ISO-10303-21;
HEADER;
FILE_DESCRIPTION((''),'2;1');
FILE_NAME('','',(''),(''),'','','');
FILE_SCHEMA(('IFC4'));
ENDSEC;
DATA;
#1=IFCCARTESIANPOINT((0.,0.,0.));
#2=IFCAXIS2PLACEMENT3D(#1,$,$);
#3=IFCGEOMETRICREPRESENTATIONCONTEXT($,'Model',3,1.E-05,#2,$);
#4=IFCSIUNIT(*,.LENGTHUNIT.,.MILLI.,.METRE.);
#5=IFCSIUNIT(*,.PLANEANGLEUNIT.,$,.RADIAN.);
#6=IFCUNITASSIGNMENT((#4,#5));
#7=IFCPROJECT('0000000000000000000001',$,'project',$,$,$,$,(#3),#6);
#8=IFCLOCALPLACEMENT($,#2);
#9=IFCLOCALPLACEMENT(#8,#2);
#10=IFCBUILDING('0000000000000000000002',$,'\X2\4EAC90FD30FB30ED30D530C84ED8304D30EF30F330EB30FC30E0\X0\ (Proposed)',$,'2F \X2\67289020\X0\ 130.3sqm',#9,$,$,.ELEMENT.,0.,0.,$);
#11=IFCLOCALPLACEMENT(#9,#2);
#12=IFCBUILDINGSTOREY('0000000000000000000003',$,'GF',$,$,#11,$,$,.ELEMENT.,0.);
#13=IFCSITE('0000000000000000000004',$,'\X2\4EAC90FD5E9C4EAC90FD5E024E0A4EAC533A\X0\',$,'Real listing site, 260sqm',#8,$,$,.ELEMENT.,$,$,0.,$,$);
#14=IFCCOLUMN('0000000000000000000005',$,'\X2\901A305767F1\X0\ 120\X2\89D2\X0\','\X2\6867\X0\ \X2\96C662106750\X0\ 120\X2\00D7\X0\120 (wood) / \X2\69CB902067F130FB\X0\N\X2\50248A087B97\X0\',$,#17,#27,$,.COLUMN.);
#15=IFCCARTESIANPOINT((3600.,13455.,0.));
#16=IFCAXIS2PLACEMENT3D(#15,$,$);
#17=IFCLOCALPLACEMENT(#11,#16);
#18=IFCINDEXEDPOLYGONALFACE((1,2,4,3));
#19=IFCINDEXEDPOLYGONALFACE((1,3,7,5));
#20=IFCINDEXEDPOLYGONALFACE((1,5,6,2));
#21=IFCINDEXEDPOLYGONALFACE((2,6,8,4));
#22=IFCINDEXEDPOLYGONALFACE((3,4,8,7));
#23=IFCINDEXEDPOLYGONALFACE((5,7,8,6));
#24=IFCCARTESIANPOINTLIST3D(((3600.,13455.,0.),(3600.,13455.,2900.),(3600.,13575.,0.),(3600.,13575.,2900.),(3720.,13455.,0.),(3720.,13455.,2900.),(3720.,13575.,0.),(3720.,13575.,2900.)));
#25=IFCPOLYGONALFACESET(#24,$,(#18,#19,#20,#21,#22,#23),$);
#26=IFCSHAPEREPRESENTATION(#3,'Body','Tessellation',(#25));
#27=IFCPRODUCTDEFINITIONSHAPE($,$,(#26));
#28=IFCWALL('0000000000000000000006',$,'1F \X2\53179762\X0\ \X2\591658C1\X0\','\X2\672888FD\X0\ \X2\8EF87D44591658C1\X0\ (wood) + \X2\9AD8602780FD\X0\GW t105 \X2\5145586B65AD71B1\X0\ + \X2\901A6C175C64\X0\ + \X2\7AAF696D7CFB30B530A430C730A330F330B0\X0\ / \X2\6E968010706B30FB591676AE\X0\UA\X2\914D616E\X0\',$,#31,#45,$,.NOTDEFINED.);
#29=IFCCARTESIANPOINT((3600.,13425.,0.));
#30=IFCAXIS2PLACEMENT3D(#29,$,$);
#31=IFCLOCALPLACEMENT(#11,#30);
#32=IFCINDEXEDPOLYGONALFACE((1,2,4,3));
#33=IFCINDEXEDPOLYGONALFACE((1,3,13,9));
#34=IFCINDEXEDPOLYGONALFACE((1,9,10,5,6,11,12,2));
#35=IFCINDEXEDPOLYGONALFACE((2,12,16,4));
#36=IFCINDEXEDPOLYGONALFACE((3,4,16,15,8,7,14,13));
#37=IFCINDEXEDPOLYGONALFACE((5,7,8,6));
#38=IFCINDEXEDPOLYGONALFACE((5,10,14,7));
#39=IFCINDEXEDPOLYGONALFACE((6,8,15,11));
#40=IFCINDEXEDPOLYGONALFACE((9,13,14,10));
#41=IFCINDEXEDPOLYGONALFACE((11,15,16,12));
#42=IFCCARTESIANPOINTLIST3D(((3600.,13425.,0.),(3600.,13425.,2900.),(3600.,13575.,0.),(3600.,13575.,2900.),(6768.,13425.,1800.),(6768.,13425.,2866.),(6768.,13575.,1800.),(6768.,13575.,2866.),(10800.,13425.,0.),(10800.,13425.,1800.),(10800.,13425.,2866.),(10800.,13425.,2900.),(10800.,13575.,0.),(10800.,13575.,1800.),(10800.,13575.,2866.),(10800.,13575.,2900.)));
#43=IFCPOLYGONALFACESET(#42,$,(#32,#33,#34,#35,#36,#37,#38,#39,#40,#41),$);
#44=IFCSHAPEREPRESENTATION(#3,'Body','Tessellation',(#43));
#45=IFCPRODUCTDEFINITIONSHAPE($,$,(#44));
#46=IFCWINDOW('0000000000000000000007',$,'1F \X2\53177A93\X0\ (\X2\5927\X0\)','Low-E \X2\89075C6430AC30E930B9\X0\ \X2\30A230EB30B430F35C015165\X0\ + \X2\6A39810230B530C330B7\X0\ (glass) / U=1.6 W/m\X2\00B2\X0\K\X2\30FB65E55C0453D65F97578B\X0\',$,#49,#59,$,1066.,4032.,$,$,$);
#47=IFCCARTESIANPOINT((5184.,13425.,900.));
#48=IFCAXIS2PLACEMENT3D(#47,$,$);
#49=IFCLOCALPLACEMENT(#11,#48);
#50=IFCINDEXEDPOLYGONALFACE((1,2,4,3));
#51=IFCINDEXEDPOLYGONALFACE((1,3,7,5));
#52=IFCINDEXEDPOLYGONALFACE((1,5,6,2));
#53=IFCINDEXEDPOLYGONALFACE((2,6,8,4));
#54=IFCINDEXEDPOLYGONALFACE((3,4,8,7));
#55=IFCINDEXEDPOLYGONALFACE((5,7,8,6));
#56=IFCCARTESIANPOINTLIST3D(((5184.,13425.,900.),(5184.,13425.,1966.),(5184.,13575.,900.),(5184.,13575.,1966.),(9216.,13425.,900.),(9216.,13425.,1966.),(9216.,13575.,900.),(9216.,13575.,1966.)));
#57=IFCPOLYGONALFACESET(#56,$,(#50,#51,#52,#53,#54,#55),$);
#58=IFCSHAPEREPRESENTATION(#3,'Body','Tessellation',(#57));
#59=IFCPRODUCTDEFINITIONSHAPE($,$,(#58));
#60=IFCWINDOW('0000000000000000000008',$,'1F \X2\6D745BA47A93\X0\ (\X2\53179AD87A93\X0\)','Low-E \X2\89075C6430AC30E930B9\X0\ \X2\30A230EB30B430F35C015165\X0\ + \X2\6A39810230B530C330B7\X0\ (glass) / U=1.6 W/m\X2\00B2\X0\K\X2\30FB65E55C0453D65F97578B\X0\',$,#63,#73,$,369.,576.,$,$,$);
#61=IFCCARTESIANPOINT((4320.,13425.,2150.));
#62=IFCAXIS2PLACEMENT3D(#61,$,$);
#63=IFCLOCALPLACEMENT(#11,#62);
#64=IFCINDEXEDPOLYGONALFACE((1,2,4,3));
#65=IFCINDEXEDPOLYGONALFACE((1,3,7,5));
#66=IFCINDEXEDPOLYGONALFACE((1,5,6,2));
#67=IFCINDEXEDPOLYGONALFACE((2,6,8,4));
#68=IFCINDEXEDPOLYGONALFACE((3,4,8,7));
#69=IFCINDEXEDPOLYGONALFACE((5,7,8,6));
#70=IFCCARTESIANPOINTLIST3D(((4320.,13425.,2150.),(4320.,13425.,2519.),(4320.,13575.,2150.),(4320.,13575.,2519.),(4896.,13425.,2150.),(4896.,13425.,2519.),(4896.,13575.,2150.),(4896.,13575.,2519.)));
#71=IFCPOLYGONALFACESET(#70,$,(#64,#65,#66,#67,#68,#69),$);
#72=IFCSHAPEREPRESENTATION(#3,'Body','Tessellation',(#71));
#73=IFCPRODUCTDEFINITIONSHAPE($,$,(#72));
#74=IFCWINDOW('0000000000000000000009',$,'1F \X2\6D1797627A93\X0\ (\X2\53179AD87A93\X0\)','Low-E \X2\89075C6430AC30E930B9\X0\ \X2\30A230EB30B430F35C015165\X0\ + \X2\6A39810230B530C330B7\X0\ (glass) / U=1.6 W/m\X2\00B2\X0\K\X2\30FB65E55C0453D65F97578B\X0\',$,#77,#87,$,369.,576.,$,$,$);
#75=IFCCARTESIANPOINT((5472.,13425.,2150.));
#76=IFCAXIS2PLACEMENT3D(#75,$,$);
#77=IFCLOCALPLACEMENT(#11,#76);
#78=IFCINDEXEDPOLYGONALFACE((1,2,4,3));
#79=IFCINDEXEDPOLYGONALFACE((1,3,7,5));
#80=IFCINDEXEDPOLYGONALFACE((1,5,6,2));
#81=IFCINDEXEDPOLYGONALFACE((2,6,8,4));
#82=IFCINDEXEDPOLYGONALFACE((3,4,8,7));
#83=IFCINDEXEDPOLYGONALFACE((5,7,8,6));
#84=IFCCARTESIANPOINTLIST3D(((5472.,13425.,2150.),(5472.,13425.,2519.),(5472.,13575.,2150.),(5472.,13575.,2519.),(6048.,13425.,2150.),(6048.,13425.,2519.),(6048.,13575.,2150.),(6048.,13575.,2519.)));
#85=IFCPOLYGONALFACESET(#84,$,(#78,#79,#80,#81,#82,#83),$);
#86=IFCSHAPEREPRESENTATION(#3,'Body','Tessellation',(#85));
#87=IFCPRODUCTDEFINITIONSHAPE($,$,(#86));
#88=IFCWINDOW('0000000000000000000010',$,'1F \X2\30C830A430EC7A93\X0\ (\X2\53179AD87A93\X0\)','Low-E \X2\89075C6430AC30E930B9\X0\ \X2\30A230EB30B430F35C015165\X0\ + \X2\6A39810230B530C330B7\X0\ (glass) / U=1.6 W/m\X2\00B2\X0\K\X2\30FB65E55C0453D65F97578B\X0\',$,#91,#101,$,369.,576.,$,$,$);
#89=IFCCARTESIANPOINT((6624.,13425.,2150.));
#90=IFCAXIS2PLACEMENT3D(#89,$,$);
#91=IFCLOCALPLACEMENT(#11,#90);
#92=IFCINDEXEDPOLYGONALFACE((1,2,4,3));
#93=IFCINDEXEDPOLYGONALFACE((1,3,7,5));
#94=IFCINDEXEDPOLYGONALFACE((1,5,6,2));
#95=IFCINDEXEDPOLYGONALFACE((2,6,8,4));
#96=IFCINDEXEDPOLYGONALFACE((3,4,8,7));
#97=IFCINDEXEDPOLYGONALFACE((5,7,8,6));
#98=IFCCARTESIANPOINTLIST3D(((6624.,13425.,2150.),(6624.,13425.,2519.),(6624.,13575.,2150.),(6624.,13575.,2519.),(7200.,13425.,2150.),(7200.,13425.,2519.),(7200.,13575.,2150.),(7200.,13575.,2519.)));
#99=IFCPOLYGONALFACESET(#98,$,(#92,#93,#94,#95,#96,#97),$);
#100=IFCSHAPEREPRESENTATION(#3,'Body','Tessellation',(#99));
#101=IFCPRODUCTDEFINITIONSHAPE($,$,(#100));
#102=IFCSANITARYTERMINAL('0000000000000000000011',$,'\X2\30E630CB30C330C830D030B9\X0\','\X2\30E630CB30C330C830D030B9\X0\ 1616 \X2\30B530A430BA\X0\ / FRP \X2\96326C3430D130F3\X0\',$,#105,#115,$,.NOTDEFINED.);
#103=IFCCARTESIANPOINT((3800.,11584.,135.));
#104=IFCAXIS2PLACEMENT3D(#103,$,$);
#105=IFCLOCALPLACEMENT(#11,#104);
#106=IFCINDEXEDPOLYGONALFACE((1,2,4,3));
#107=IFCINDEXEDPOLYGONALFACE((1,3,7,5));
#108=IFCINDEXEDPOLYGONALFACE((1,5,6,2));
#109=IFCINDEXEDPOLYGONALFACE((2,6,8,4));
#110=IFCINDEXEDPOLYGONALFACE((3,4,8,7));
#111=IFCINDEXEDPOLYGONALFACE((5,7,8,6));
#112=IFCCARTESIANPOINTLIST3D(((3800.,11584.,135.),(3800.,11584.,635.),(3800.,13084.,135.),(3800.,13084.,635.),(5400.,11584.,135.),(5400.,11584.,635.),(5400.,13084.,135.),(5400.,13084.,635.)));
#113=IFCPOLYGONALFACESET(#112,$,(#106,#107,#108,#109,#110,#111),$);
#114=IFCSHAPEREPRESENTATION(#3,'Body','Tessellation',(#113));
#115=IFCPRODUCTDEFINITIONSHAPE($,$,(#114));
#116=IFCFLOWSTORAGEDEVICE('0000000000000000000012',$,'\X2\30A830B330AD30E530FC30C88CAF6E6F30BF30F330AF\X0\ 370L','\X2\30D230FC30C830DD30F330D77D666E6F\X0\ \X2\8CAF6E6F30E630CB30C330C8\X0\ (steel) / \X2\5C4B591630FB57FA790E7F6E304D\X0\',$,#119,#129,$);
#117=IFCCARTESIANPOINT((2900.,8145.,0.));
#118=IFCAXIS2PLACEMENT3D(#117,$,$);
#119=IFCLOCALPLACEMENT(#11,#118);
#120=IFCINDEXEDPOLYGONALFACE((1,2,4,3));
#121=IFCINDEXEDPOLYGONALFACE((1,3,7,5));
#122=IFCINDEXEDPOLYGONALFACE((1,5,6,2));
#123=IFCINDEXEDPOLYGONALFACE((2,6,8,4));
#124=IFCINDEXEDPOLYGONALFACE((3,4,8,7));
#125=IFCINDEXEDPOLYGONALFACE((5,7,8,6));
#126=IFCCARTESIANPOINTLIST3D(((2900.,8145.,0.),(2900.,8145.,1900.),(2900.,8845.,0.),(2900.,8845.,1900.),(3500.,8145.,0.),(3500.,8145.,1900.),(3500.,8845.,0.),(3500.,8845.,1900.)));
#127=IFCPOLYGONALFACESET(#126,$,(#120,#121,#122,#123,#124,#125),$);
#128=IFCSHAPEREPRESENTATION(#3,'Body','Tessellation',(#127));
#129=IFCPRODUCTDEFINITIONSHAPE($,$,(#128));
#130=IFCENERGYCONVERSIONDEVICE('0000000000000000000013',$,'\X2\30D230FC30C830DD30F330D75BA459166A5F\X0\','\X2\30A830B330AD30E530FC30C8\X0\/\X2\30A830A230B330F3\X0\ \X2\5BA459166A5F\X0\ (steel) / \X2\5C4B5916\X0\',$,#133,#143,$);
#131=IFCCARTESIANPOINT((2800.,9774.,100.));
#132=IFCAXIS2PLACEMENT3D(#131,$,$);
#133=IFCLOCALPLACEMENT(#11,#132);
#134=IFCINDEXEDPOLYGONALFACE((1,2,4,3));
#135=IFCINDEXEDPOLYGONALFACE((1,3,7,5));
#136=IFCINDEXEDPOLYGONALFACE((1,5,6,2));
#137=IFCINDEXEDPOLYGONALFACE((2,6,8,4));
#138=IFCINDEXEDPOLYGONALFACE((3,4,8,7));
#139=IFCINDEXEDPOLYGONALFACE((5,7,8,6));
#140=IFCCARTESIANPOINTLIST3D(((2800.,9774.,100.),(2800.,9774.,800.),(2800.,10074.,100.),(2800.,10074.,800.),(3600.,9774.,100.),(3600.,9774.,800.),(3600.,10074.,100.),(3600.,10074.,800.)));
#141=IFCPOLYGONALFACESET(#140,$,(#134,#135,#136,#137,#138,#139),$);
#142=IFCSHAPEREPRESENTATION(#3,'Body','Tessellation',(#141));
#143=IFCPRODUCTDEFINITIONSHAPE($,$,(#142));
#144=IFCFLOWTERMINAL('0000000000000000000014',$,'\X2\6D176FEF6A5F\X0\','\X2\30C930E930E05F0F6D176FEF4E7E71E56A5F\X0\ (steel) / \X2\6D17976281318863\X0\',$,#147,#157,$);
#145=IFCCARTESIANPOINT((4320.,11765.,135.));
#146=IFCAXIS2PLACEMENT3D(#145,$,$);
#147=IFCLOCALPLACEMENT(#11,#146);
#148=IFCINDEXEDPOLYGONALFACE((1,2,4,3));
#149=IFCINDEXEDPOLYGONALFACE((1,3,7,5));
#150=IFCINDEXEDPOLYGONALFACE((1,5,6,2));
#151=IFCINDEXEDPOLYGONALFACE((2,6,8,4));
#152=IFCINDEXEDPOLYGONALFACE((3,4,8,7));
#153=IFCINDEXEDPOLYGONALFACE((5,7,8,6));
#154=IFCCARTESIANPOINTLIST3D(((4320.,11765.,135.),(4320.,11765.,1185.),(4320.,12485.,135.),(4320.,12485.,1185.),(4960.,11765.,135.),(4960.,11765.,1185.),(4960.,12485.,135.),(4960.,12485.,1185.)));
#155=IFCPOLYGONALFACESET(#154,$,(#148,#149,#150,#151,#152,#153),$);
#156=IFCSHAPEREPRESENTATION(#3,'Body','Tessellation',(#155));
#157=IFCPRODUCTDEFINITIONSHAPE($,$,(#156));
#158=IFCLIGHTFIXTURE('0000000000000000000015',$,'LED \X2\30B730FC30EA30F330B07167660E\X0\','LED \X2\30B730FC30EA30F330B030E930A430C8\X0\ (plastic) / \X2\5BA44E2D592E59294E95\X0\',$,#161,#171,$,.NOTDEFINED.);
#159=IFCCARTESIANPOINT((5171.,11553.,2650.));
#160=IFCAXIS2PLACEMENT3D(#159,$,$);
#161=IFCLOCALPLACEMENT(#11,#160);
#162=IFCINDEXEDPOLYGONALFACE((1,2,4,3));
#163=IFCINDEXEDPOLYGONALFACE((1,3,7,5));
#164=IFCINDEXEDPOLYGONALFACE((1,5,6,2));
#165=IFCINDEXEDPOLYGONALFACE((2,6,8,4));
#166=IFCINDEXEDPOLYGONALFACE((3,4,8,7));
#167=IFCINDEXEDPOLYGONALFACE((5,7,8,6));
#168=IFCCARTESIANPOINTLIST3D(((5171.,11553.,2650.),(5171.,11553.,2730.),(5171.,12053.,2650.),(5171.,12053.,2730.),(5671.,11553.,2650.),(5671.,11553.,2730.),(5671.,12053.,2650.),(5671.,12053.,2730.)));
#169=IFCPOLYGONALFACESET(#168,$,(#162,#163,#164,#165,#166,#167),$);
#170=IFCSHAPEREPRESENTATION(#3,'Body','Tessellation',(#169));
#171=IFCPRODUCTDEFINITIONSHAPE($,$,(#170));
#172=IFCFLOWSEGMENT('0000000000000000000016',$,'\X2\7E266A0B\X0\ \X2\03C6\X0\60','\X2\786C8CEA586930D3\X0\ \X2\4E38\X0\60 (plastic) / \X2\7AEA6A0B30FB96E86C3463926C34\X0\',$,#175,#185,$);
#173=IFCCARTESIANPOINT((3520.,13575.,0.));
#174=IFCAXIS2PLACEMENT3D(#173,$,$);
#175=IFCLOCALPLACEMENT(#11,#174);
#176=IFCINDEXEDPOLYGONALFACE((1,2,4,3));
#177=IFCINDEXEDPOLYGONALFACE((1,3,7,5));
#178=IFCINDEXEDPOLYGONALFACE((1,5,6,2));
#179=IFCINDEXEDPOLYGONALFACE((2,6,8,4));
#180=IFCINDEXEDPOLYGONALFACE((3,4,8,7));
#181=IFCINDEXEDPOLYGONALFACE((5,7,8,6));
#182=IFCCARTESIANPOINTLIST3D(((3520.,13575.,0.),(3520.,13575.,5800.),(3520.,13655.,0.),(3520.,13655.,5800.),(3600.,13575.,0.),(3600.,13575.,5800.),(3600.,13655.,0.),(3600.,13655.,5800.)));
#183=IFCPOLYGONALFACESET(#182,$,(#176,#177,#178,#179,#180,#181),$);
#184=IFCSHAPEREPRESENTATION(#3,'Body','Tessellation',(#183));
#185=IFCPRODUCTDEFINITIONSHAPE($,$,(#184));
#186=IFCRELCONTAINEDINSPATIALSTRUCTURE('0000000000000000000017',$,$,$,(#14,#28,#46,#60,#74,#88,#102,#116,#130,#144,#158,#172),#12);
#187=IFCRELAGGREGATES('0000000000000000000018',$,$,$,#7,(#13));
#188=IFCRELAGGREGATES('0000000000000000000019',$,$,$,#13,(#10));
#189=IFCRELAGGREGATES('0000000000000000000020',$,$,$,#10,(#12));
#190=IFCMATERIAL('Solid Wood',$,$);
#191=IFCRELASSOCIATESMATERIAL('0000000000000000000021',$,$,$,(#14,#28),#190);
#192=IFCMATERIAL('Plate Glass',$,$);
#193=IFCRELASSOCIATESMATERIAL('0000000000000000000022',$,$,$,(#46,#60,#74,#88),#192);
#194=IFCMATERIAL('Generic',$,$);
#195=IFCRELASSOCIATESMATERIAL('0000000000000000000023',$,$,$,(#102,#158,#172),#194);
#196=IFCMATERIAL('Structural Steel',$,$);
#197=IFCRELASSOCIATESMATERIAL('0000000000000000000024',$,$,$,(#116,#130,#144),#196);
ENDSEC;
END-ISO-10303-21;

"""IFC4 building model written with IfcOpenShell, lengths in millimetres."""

from ifc_helpers import new_model, si_unit, frame, frame_2d, origin, place, context, project, spatial, rectangle, extrude, material, element, fill, save


model = new_model("IFC4")

# Units and contexts
model_context = context("Model", 3, precision=1e-05, world=origin())
ifc_project = project(units=[si_unit("LENGTHUNIT", "METRE", prefix="MILLI"), si_unit("PLANEANGLEUNIT", "RADIAN")], contexts=[model_context])

# Site, building, storey
site_placement = place(None, origin())
site = spatial("IfcSite", under=ifc_project, at=site_placement, Name="京都府京都市上京区", ObjectType="Real listing site, 260sqm", CompositionType="ELEMENT", RefElevation=0.0)
building_placement = place(site_placement, origin())
building = spatial("IfcBuilding", under=site, at=building_placement, Name="京都・ロフト付きワンルーム (Proposed)", ObjectType="2F 木造 130.3sqm", CompositionType="ELEMENT", ElevationOfRefHeight=0.0, ElevationOfTerrain=0.0)
storey_placement = place(building_placement, origin())
storey = spatial("IfcBuildingStorey", under=building, at=storey_placement, Name="GF", CompositionType="ELEMENT", Elevation=0.0)

# Column
ifc_material_1 = material(Name="Solid Wood")
column_1_placement = place(storey_placement, frame((3600.0, 13455.0, 0.0)))
element("IfcColumn", 1, at=column_1_placement, inside=storey, material=ifc_material_1, Name="通し柱 120角", Description="桧 集成材 120×120 (wood) / 構造柱・N値計算", PredefinedType="COLUMN", context=model_context, shape_type="SweptSolid", body=[
    extrude(rectangle(XDim=120.0, YDim=120.0, at=frame_2d((60.0, 60.0))), frame((3600.0, 13455.0, 0.0)), (0.0, 0.0, 1.0), 2900.0),
])

# Wall, openings, windows
wall_1_placement = place(storey_placement, frame((3600.0, 13425.0, 0.0)))
wall_1 = element("IfcWall", 2, at=wall_1_placement, inside=storey, material=ifc_material_1, Name="1F 北面 外壁", Description="木製 軸組外壁 (wood) + 高性能GW t105 充填断熱 + 通気層 + 窯業系サイディング / 準耐火・外皮UA配慮", PredefinedType="NOTDEFINED", context=model_context, shape_type="SweptSolid", body=[
    extrude(rectangle(XDim=7200.0, YDim=150.0, at=frame_2d((3600.0, 75.0))), frame((3600.0, 13425.0, 0.0)), (0.0, 0.0, 1.0), 2900.0),
])
opening_1_placement = place(storey_placement, frame((5184.0, 13425.0, 900.0)))
opening_1 = element("IfcOpeningElement", 3, at=opening_1_placement, cuts=wall_1, PredefinedType="NOTDEFINED", context=model_context, shape_type="SweptSolid", body=[
    extrude(rectangle(XDim=4032.0, YDim=150.0, at=frame_2d((2016.0, 75.0))), frame((5184.0, 13425.0, 900.0)), (0.0, 0.0, 1.0), 1066.0),
])
opening_2_placement = place(storey_placement, frame((4320.0, 13425.0, 2150.0)))
opening_2 = element("IfcOpeningElement", 4, at=opening_2_placement, cuts=wall_1, PredefinedType="NOTDEFINED", context=model_context, shape_type="SweptSolid", body=[
    extrude(rectangle(XDim=576.0, YDim=150.0, at=frame_2d((288.0, 75.0))), frame((4320.0, 13425.0, 2150.0)), (0.0, 0.0, 1.0), 369.0),
])
opening_3_placement = place(storey_placement, frame((5472.0, 13425.0, 2150.0)))
opening_3 = element("IfcOpeningElement", 5, at=opening_3_placement, cuts=wall_1, PredefinedType="NOTDEFINED", context=model_context, shape_type="SweptSolid", body=[
    extrude(rectangle(XDim=576.0, YDim=150.0, at=frame_2d((288.0, 75.0))), frame((5472.0, 13425.0, 2150.0)), (0.0, 0.0, 1.0), 369.0),
])
opening_4_placement = place(storey_placement, frame((6624.0, 13425.0, 2150.0)))
opening_4 = element("IfcOpeningElement", 6, at=opening_4_placement, cuts=wall_1, PredefinedType="NOTDEFINED", context=model_context, shape_type="SweptSolid", body=[
    extrude(rectangle(XDim=576.0, YDim=150.0, at=frame_2d((288.0, 75.0))), frame((6624.0, 13425.0, 2150.0)), (0.0, 0.0, 1.0), 369.0),
])
ifc_material_2 = material(Name="Plate Glass")
window_1_placement = place(storey_placement, frame((5184.0, 13425.0, 900.0)))
window_1 = element("IfcWindow", 7, at=window_1_placement, inside=storey, material=ifc_material_2, Name="1F 北窓 (大)", Description="Low-E 複層ガラス アルゴン封入 + 樹脂サッシ (glass) / U=1.6 W/m²K・日射取得型", OverallHeight=1066.0, OverallWidth=4032.0, context=model_context, shape_type="SweptSolid", body=[
    extrude(rectangle(XDim=4032.0, YDim=150.0, at=frame_2d((2016.0, 75.0))), frame((5184.0, 13425.0, 900.0)), (0.0, 0.0, 1.0), 1066.0),
])
fill(opening_1, window_1)
window_2_placement = place(storey_placement, frame((4320.0, 13425.0, 2150.0)))
window_2 = element("IfcWindow", 8, at=window_2_placement, inside=storey, material=ifc_material_2, Name="1F 浴室窓 (北高窓)", Description="Low-E 複層ガラス アルゴン封入 + 樹脂サッシ (glass) / U=1.6 W/m²K・日射取得型", OverallHeight=369.0, OverallWidth=576.0, context=model_context, shape_type="SweptSolid", body=[
    extrude(rectangle(XDim=576.0, YDim=150.0, at=frame_2d((288.0, 75.0))), frame((4320.0, 13425.0, 2150.0)), (0.0, 0.0, 1.0), 369.0),
])
fill(opening_2, window_2)
window_3_placement = place(storey_placement, frame((5472.0, 13425.0, 2150.0)))
window_3 = element("IfcWindow", 9, at=window_3_placement, inside=storey, material=ifc_material_2, Name="1F 洗面窓 (北高窓)", Description="Low-E 複層ガラス アルゴン封入 + 樹脂サッシ (glass) / U=1.6 W/m²K・日射取得型", OverallHeight=369.0, OverallWidth=576.0, context=model_context, shape_type="SweptSolid", body=[
    extrude(rectangle(XDim=576.0, YDim=150.0, at=frame_2d((288.0, 75.0))), frame((5472.0, 13425.0, 2150.0)), (0.0, 0.0, 1.0), 369.0),
])
fill(opening_3, window_3)
window_4_placement = place(storey_placement, frame((6624.0, 13425.0, 2150.0)))
window_4 = element("IfcWindow", 10, at=window_4_placement, inside=storey, material=ifc_material_2, Name="1F トイレ窓 (北高窓)", Description="Low-E 複層ガラス アルゴン封入 + 樹脂サッシ (glass) / U=1.6 W/m²K・日射取得型", OverallHeight=369.0, OverallWidth=576.0, context=model_context, shape_type="SweptSolid", body=[
    extrude(rectangle(XDim=576.0, YDim=150.0, at=frame_2d((288.0, 75.0))), frame((6624.0, 13425.0, 2150.0)), (0.0, 0.0, 1.0), 369.0),
])
fill(opening_4, window_4)

# Sanitary terminal
ifc_material_3 = material(Name="Generic")
sanitary_terminal_placement = place(storey_placement, frame((3800.0, 11584.0, 135.0)))
element("IfcSanitaryTerminal", 11, at=sanitary_terminal_placement, inside=storey, material=ifc_material_3, Name="ユニットバス", Description="ユニットバス 1616 サイズ / FRP 防水パン", PredefinedType="NOTDEFINED", context=model_context, shape_type="SweptSolid", body=[
    extrude(rectangle(XDim=1600.0, YDim=1500.0, at=frame_2d((800.0, 750.0))), frame((3800.0, 11584.0, 135.0)), (0.0, 0.0, 1.0), 500.0),
])

# Flow storage device
ifc_material_4 = material(Name="Structural Steel")
flow_storage_device_placement = place(storey_placement, frame((2900.0, 8145.0, 0.0)))
element("IfcFlowStorageDevice", 12, at=flow_storage_device_placement, inside=storey, material=ifc_material_4, Name="エコキュート貯湯タンク 370L", Description="ヒートポンプ給湯 貯湯ユニット (steel) / 屋外・基礎置き", context=model_context, shape_type="SweptSolid", body=[
    extrude(rectangle(XDim=600.0, YDim=700.0, at=frame_2d((300.0, 350.0))), frame((2900.0, 8145.0, 0.0)), (0.0, 0.0, 1.0), 1900.0),
])

# Energy conversion device
energy_conversion_device_placement = place(storey_placement, frame((2800.0, 9774.0, 100.0)))
element("IfcEnergyConversionDevice", 13, at=energy_conversion_device_placement, inside=storey, material=ifc_material_4, Name="ヒートポンプ室外機", Description="エコキュート/エアコン 室外機 (steel) / 屋外", context=model_context, shape_type="SweptSolid", body=[
    extrude(rectangle(XDim=800.0, YDim=300.0, at=frame_2d((400.0, 150.0))), frame((2800.0, 9774.0, 100.0)), (0.0, 0.0, 1.0), 700.0),
])

# Flow terminal
flow_terminal_placement = place(storey_placement, frame((4320.0, 11765.0, 135.0)))
element("IfcFlowTerminal", 14, at=flow_terminal_placement, inside=storey, material=ifc_material_4, Name="洗濯機", Description="ドラム式洗濯乾燥機 (steel) / 洗面脱衣", context=model_context, shape_type="SweptSolid", body=[
    extrude(rectangle(XDim=640.0, YDim=720.0, at=frame_2d((320.0, 360.0))), frame((4320.0, 11765.0, 135.0)), (0.0, 0.0, 1.0), 1050.0),
])

# Light fixture
light_fixture_placement = place(storey_placement, frame((5171.0, 11553.0, 2650.0)))
element("IfcLightFixture", 15, at=light_fixture_placement, inside=storey, material=ifc_material_3, Name="LED シーリング照明", Description="LED シーリングライト (plastic) / 室中央天井", PredefinedType="NOTDEFINED", context=model_context, shape_type="SweptSolid", body=[
    extrude(rectangle(XDim=500.0, YDim=500.0, at=frame_2d((250.0, 250.0))), frame((5171.0, 11553.0, 2650.0)), (0.0, 0.0, 1.0), 80.0),
])

# Flow segment
flow_segment_placement = place(storey_placement, frame((3520.0, 13575.0, 0.0)))
element("IfcFlowSegment", 16, at=flow_segment_placement, inside=storey, material=ifc_material_3, Name="縦樋 φ60", Description="硬質塩ビ 丸60 (plastic) / 竪樋・雨水排水", context=model_context, shape_type="SweptSolid", body=[
    extrude(rectangle(XDim=80.0, YDim=80.0, at=frame_2d((40.0, 40.0))), frame((3520.0, 13575.0, 0.0)), (0.0, 0.0, 1.0), 5800.0),
])

save(model, "model.ifc")
